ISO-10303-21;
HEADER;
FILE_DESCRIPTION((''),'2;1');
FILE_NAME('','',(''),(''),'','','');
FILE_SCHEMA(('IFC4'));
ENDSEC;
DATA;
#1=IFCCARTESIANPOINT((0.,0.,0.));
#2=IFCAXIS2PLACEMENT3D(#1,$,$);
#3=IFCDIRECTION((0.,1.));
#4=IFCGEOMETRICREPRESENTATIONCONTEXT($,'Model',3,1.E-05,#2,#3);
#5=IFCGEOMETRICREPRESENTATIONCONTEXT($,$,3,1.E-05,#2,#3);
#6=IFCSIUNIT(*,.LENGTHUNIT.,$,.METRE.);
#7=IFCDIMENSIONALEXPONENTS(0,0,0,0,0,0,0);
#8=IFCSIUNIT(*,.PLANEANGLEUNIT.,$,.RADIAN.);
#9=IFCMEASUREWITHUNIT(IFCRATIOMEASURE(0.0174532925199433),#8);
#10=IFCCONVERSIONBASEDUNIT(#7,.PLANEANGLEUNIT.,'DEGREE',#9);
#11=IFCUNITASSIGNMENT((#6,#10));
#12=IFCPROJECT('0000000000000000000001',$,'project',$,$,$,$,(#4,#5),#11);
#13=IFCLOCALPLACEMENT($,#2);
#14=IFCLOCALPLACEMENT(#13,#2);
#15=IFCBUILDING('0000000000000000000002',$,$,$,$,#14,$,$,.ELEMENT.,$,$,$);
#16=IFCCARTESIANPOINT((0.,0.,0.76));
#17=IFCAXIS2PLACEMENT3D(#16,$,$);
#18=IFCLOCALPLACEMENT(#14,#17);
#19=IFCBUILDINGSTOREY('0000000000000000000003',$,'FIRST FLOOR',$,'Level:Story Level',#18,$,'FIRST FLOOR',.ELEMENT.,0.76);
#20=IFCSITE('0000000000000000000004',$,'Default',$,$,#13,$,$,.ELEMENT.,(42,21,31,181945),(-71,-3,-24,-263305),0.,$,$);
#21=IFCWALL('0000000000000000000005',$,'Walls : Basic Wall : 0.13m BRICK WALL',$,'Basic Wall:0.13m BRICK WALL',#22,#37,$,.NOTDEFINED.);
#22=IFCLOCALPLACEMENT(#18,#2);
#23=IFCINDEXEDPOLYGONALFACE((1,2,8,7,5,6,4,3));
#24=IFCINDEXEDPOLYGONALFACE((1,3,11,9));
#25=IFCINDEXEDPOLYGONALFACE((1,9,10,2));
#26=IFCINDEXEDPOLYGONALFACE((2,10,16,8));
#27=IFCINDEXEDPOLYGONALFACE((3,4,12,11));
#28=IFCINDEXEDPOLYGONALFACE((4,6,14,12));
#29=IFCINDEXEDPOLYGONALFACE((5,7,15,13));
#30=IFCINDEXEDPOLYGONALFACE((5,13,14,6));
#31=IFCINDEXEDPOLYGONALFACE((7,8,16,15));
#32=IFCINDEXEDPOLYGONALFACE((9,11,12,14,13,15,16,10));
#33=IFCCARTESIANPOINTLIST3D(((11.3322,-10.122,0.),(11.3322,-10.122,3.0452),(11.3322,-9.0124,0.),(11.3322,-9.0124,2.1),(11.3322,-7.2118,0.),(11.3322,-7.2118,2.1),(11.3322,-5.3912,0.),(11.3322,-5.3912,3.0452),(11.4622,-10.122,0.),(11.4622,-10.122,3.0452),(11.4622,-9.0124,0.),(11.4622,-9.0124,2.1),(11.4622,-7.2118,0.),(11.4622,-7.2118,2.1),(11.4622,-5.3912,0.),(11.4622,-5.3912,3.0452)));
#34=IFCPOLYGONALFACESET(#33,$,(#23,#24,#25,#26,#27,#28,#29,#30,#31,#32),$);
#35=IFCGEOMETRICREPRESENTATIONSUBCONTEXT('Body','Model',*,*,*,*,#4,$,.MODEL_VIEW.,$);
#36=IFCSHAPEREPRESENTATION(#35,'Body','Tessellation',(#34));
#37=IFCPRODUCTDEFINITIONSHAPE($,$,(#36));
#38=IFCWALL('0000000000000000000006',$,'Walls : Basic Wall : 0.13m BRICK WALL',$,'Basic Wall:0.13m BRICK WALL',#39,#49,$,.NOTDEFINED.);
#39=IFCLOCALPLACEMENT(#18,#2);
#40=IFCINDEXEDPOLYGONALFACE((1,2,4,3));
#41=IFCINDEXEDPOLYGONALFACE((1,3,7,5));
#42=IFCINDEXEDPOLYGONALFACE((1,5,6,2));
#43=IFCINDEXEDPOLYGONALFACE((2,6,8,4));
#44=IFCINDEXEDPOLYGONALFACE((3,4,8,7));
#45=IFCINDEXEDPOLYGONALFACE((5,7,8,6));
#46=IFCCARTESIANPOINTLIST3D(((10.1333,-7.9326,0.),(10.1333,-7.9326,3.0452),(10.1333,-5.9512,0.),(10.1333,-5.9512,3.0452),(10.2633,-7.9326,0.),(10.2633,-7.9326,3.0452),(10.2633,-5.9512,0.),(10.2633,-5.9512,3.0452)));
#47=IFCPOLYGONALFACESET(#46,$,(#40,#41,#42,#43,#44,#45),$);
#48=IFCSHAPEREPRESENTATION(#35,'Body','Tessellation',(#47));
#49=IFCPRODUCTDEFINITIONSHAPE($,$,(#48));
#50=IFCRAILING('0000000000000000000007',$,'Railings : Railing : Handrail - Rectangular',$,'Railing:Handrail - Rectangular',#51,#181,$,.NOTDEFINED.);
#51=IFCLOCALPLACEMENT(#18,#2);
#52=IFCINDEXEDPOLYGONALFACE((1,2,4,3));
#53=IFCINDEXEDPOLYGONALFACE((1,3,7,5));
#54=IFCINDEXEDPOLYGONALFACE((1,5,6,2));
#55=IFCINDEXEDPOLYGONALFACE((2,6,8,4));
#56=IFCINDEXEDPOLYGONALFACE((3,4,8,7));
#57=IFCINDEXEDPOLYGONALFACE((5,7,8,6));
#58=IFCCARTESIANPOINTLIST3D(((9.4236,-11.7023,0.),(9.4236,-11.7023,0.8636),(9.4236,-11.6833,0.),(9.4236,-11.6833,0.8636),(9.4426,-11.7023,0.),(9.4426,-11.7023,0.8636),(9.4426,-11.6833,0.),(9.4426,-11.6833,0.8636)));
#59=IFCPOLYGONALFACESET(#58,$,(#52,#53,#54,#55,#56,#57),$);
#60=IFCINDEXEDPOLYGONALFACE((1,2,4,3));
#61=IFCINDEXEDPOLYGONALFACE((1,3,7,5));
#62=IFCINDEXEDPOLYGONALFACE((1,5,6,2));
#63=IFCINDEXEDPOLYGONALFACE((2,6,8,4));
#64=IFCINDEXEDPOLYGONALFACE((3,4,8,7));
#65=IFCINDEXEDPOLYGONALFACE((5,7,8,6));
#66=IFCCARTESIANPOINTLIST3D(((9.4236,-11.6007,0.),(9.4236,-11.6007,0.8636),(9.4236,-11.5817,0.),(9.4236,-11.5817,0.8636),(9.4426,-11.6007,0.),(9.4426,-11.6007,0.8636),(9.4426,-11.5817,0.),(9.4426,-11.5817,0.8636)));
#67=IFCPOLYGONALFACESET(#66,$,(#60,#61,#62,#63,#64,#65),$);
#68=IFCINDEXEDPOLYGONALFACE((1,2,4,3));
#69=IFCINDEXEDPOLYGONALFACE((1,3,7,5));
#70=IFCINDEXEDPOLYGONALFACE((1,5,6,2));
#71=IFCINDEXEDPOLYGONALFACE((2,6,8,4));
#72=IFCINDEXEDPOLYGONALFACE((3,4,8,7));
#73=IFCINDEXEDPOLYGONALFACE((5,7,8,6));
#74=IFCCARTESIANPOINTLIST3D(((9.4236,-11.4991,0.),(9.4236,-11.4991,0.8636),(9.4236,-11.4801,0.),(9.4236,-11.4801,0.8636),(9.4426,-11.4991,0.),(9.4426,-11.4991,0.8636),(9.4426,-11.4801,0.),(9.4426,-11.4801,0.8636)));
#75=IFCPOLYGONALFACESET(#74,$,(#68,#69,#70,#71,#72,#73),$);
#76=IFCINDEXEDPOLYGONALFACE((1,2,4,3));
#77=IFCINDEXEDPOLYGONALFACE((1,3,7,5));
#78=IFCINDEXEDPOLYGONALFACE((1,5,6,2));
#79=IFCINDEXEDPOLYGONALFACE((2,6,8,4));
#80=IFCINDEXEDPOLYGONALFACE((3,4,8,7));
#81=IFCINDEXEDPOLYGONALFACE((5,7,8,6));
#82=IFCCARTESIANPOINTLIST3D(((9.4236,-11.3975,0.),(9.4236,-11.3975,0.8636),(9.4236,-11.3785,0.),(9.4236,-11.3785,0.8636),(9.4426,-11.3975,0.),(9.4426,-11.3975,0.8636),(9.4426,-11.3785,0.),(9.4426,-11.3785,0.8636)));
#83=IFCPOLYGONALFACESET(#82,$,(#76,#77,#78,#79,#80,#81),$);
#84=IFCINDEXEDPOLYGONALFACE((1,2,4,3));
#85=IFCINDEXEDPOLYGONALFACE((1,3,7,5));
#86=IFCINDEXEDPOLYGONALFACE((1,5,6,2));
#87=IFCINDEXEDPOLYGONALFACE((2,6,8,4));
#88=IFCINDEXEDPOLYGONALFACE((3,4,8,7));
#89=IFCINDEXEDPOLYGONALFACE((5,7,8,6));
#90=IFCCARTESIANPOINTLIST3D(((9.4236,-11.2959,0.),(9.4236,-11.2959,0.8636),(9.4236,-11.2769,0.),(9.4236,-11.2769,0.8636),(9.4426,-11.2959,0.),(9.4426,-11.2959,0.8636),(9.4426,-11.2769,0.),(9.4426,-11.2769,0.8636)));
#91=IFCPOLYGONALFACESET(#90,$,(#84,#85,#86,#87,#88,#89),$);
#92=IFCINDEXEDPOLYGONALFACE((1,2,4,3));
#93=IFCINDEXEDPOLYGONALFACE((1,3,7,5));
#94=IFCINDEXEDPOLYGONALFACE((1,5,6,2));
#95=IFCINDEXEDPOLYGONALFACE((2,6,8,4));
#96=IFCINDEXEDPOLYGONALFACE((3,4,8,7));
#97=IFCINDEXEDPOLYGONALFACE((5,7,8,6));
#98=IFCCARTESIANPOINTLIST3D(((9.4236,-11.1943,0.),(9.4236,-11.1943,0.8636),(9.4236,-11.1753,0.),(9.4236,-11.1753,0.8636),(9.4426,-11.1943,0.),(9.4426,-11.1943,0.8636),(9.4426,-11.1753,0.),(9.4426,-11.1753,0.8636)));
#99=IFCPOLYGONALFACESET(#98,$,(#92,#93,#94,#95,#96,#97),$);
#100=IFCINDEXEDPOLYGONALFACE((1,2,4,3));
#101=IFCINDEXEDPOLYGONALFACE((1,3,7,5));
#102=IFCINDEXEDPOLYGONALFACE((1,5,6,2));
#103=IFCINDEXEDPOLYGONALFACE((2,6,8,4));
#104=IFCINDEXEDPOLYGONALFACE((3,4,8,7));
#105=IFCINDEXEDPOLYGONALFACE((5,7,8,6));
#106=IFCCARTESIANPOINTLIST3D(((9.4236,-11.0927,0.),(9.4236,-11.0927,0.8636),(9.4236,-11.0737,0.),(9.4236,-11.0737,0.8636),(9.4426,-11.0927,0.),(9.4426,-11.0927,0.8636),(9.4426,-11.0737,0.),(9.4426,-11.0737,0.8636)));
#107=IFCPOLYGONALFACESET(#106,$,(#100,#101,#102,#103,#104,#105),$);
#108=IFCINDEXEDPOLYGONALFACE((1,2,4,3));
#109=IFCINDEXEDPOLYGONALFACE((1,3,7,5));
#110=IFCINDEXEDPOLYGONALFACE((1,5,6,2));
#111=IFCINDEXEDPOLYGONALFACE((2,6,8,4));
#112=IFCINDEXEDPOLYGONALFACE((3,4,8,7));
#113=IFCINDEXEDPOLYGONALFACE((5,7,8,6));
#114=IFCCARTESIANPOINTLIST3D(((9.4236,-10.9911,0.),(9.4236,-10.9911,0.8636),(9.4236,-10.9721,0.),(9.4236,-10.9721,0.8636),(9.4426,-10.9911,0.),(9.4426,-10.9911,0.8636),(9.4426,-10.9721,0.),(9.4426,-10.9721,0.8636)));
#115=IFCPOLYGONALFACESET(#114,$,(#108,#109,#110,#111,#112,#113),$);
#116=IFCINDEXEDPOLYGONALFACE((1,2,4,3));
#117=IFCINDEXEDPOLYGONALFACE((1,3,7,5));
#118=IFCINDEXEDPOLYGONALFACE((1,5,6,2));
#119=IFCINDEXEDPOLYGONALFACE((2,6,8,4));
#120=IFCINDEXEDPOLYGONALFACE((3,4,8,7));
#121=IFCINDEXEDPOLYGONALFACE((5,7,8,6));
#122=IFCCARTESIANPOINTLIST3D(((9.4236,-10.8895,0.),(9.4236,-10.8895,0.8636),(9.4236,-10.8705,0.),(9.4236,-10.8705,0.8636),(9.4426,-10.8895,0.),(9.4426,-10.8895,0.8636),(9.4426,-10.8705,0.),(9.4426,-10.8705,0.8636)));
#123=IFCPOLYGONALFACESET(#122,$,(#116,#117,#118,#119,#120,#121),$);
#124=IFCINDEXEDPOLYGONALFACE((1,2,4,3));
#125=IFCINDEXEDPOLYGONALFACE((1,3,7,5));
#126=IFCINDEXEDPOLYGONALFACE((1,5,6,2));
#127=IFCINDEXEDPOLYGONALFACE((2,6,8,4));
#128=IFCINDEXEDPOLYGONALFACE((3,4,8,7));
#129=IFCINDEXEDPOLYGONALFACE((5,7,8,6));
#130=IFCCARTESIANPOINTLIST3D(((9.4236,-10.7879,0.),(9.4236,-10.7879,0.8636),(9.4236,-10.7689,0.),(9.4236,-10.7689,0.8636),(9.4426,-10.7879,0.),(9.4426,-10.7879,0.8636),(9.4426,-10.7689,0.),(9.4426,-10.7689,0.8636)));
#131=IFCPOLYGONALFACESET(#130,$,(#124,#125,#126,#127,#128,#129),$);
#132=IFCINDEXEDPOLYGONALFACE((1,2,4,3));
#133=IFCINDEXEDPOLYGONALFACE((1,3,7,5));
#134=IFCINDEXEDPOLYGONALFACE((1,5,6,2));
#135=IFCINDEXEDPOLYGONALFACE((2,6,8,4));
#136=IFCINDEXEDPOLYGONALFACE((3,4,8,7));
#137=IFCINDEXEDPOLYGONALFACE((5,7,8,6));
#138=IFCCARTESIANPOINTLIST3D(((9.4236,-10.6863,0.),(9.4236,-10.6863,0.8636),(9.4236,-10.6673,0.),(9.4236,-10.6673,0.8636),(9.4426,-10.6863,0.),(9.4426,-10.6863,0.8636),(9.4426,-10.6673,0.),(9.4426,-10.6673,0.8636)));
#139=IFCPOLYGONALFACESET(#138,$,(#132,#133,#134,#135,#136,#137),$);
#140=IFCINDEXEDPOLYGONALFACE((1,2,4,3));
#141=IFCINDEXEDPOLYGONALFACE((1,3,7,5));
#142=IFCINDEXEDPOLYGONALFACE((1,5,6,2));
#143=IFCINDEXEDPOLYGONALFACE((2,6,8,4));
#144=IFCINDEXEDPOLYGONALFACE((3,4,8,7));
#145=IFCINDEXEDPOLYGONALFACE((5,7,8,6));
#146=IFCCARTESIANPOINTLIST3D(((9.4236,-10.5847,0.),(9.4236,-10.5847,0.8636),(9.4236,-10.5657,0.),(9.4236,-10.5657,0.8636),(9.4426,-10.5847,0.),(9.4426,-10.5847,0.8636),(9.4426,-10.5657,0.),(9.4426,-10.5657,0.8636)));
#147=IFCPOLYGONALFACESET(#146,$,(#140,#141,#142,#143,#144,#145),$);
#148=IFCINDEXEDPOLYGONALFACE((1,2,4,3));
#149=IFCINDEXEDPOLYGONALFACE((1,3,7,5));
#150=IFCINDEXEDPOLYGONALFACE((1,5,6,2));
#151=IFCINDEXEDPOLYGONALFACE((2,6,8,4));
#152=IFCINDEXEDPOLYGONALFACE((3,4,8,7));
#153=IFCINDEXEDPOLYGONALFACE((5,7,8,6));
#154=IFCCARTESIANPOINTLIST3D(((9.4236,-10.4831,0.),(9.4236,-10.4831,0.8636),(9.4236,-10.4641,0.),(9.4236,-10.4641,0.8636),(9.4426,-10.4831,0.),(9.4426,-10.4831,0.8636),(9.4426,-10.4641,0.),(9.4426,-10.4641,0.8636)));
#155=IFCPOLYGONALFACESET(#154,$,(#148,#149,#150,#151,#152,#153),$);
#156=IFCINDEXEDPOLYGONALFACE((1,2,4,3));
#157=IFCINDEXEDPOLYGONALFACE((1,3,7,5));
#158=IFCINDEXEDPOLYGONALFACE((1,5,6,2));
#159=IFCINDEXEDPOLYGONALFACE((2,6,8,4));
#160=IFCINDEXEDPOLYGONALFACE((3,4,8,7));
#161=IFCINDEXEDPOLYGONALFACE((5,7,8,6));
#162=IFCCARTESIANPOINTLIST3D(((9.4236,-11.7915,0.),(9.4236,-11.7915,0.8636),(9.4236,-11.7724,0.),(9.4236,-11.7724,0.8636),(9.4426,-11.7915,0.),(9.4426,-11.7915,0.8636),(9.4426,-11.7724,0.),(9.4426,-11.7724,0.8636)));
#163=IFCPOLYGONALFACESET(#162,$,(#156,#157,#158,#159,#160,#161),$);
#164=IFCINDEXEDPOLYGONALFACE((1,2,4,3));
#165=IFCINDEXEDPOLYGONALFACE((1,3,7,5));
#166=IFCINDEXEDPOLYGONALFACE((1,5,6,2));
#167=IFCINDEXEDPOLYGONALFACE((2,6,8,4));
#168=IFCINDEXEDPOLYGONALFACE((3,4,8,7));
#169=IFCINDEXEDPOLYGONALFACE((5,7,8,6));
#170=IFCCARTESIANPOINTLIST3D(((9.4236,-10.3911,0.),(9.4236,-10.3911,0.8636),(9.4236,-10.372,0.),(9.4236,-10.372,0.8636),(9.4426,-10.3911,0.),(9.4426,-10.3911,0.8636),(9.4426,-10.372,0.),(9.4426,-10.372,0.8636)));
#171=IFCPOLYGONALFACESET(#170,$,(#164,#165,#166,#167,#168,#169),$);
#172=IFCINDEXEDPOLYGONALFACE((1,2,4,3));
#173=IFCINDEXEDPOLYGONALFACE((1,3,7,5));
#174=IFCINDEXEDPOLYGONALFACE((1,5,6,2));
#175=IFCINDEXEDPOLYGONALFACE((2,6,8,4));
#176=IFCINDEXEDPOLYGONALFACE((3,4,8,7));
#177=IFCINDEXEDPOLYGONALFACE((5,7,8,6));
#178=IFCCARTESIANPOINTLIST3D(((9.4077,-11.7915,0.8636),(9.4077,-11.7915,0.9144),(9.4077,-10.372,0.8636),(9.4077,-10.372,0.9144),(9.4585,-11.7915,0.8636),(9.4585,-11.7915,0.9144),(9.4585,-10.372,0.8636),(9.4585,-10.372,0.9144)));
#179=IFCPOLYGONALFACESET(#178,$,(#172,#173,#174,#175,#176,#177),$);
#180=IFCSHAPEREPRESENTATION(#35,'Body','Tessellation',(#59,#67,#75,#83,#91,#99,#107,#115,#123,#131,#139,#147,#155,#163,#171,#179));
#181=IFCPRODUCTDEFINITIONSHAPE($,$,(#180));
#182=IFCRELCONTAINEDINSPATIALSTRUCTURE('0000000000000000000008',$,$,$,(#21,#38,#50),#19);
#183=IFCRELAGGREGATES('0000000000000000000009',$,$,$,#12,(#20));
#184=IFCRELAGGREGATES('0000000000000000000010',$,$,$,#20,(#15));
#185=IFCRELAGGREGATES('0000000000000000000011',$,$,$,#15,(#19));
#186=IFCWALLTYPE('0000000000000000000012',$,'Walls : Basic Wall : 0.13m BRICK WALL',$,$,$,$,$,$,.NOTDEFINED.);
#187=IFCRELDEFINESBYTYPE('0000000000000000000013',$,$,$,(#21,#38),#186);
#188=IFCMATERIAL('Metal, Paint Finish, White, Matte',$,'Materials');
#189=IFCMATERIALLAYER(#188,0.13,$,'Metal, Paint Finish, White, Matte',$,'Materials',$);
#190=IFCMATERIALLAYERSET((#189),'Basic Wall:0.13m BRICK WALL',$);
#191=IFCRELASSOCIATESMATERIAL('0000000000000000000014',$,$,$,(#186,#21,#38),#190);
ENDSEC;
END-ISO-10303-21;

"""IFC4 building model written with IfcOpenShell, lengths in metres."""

from ifc_helpers import new_model, entity, si_unit, converted_unit, direction, frame, frame_2d, origin, origin_2d_with_axis, place, context, subcontext, project, spatial, rectangle, extrude, material, layer, layer_set, layer_usage, type_object, element, save


model = new_model("IFC4")

# Units and contexts
model_context = context("Model", 3, precision=1e-05, world=origin(), true_north=direction((0.0, 1.0)))
context_of_model = context(None, 3, precision=1e-05, world=origin(), true_north=direction((0.0, 1.0)))
body_context = subcontext(model_context, "Body", "Model", "MODEL_VIEW")
ifc_project = project(units=[si_unit("LENGTHUNIT", "METRE"), converted_unit("PLANEANGLEUNIT", "DEGREE", entity("IfcRatioMeasure", 0.0174532925199433), si_unit("PLANEANGLEUNIT", "RADIAN"), dimensions=[0, 0, 0, 0, 0, 0, 0])], contexts=[model_context, context_of_model])

# Site, building, storey
site_placement = place(None, origin())
site = spatial("IfcSite", under=ifc_project, at=site_placement, Name="Default", CompositionType="ELEMENT", RefLatitude=(42, 21, 31, 181945), RefLongitude=(-71, -3, -24, -263305), RefElevation=0.0)
building_placement = place(site_placement, origin())
building = spatial("IfcBuilding", under=site, at=building_placement, CompositionType="ELEMENT")
storey_placement = place(building_placement, frame((0.0, 0.0, 0.76)))
storey = spatial("IfcBuildingStorey", under=building, at=storey_placement, Name="FIRST FLOOR", ObjectType="Level:Story Level", LongName="FIRST FLOOR", CompositionType="ELEMENT", Elevation=0.76)

# Wall, opening
ifc_material_1 = material(Name="Metal, Paint Finish, White, Matte", Category="Materials")
ifc_layer_1 = layer(ifc_material_1, 0.13, Name="Metal, Paint Finish, White, Matte", Category="Materials")
ifc_layer_set_1 = layer_set([ifc_layer_1], Name="Basic Wall:0.13m BRICK WALL")
ifc_layer_usage_1 = layer_usage(ifc_layer_set_1, "AXIS2", "NEGATIVE", 0.065)
wall_type = type_object("IfcWallType", Name="Walls : Basic Wall : 0.13m BRICK WALL", PredefinedType="NOTDEFINED", material=ifc_layer_set_1)
wall_1_placement = place(storey_placement, frame((11.3972, -10.122, 0.0), z_axis=(0.0, 0.0, 1.0), x_axis=(0.0, 1.0, 0.0)))
wall_1 = element("IfcWall", 1, at=wall_1_placement, inside=storey, type_object=wall_type, material=ifc_layer_usage_1, Name="Walls : Basic Wall : 0.13m BRICK WALL", ObjectType="Basic Wall:0.13m BRICK WALL", PredefinedType="NOTDEFINED", context=body_context, shape_type="SweptSolid", body=[
    extrude(rectangle(XDim=4.7308, YDim=0.13, at=frame_2d((2.3654, 0.0), x_axis=(-1.0, 0.0))), origin(), (0.0, 0.0, 1.0), 3.0452),
])
opening_1_placement = place(wall_1_placement, frame((1.1096, 0.065, 0.0)))
element("IfcOpeningElement", 2, at=opening_1_placement, cuts=wall_1, ObjectType="Opening", PredefinedType="OPENING", context=body_context, shape_type="SweptSolid", body=[
    extrude(rectangle(XDim=2.1, YDim=1.8006, at=frame_2d((0.0, 0.0), x_axis=(1.0, 0.0))), frame((0.9003, -0.13, 1.05), z_axis=(0.0, 1.0, 0.0), x_axis=(0.0, 0.0, -1.0)), (0.0, 0.0, 1.0), 0.13),
])

# Wall
ifc_layer_usage_2 = layer_usage(ifc_layer_set_1, "AXIS2", "NEGATIVE", 0.065)
wall_2_placement = place(storey_placement, frame((10.1983, -5.9512, 0.0), z_axis=(0.0, 0.0, 1.0), x_axis=(0.0, -1.0, 0.0)))
element("IfcWall", 3, at=wall_2_placement, inside=storey, type_object=wall_type, material=ifc_layer_usage_2, Name="Walls : Basic Wall : 0.13m BRICK WALL", ObjectType="Basic Wall:0.13m BRICK WALL", PredefinedType="NOTDEFINED", context=body_context, shape_type="SweptSolid", body=[
    extrude(rectangle(XDim=1.9814, YDim=0.13, at=frame_2d((0.9907, 0.0), x_axis=(-1.0, 0.0))), origin(), (0.0, 0.0, 1.0), 3.0452),
])

# Railing
railing_1_placement = place(storey_placement, frame((9.4077, -11.7915, 0.0)))
element("IfcRailing", 4, at=railing_1_placement, inside=storey, Name="Railings : Railing : Handrail - Rectangular", ObjectType="Railing:Handrail - Rectangular", PredefinedType="NOTDEFINED", context=body_context, shape_type="SweptSolid", body=[
    extrude(rectangle(XDim=0.0191, YDim=0.0191, at=origin_2d_with_axis()), frame((0.0254, 0.0987, 0.0), z_axis=(0.0, 0.0, 1.0), x_axis=(0.0, -1.0, 0.0)), (0.0, 0.0, 1.0), 0.8636),
    extrude(rectangle(XDim=0.0191, YDim=0.0191, at=origin_2d_with_axis()), frame((0.0254, 0.2003, 0.0), z_axis=(0.0, 0.0, 1.0), x_axis=(0.0, -1.0, 0.0)), (0.0, 0.0, 1.0), 0.8636),
    extrude(rectangle(XDim=0.0191, YDim=0.0191, at=origin_2d_with_axis()), frame((0.0254, 0.3019, 0.0), z_axis=(0.0, 0.0, 1.0), x_axis=(0.0, -1.0, 0.0)), (0.0, 0.0, 1.0), 0.8636),
    extrude(rectangle(XDim=0.0191, YDim=0.0191, at=origin_2d_with_axis()), frame((0.0254, 0.4035, 0.0), z_axis=(0.0, 0.0, 1.0), x_axis=(0.0, -1.0, 0.0)), (0.0, 0.0, 1.0), 0.8636),
    extrude(rectangle(XDim=0.0191, YDim=0.0191, at=origin_2d_with_axis()), frame((0.0254, 0.5051, 0.0), z_axis=(0.0, 0.0, 1.0), x_axis=(0.0, -1.0, 0.0)), (0.0, 0.0, 1.0), 0.8636),
    extrude(rectangle(XDim=0.0191, YDim=0.0191, at=origin_2d_with_axis()), frame((0.0254, 0.6067, 0.0), z_axis=(0.0, 0.0, 1.0), x_axis=(0.0, -1.0, 0.0)), (0.0, 0.0, 1.0), 0.8636),
    extrude(rectangle(XDim=0.0191, YDim=0.0191, at=origin_2d_with_axis()), frame((0.0254, 0.7083, 0.0), z_axis=(0.0, 0.0, 1.0), x_axis=(0.0, -1.0, 0.0)), (0.0, 0.0, 1.0), 0.8636),
    extrude(rectangle(XDim=0.0191, YDim=0.0191, at=origin_2d_with_axis()), frame((0.0254, 0.8099, 0.0), z_axis=(0.0, 0.0, 1.0), x_axis=(0.0, -1.0, 0.0)), (0.0, 0.0, 1.0), 0.8636),
    extrude(rectangle(XDim=0.0191, YDim=0.0191, at=origin_2d_with_axis()), frame((0.0254, 0.9115, 0.0), z_axis=(0.0, 0.0, 1.0), x_axis=(0.0, -1.0, 0.0)), (0.0, 0.0, 1.0), 0.8636),
    extrude(rectangle(XDim=0.0191, YDim=0.0191, at=origin_2d_with_axis()), frame((0.0254, 1.0131, 0.0), z_axis=(0.0, 0.0, 1.0), x_axis=(0.0, -1.0, 0.0)), (0.0, 0.0, 1.0), 0.8636),
    extrude(rectangle(XDim=0.0191, YDim=0.0191, at=origin_2d_with_axis()), frame((0.0254, 1.1147, 0.0), z_axis=(0.0, 0.0, 1.0), x_axis=(0.0, -1.0, 0.0)), (0.0, 0.0, 1.0), 0.8636),
    extrude(rectangle(XDim=0.0191, YDim=0.0191, at=origin_2d_with_axis()), frame((0.0254, 1.2163, 0.0), z_axis=(0.0, 0.0, 1.0), x_axis=(0.0, -1.0, 0.0)), (0.0, 0.0, 1.0), 0.8636),
    extrude(rectangle(XDim=0.0191, YDim=0.0191, at=origin_2d_with_axis()), frame((0.0254, 1.3179, 0.0), z_axis=(0.0, 0.0, 1.0), x_axis=(0.0, -1.0, 0.0)), (0.0, 0.0, 1.0), 0.8636),
    extrude(rectangle(XDim=0.0191, YDim=0.0191, at=origin_2d_with_axis()), frame((0.0254, 0.0095, 0.0), z_axis=(0.0, 0.0, 1.0), x_axis=(0.0, -1.0, 0.0)), (0.0, 0.0, 1.0), 0.8636),
    extrude(rectangle(XDim=0.0191, YDim=0.0191, at=origin_2d_with_axis()), frame((0.0254, 1.41, 0.0), z_axis=(0.0, 0.0, 1.0), x_axis=(0.0, -1.0, 0.0)), (0.0, 0.0, 1.0), 0.8636),
    extrude(rectangle(XDim=1.4195, YDim=0.0508, at=frame_2d((0.0, 0.0), x_axis=(1.0, 0.0))), frame((0.0254, 0.7097, 0.8636), z_axis=(0.0, 0.0, 1.0), x_axis=(0.0, -1.0, 0.0)), (0.0, 0.0, 1.0), 0.0508),
])

save(model, "model.ifc")
